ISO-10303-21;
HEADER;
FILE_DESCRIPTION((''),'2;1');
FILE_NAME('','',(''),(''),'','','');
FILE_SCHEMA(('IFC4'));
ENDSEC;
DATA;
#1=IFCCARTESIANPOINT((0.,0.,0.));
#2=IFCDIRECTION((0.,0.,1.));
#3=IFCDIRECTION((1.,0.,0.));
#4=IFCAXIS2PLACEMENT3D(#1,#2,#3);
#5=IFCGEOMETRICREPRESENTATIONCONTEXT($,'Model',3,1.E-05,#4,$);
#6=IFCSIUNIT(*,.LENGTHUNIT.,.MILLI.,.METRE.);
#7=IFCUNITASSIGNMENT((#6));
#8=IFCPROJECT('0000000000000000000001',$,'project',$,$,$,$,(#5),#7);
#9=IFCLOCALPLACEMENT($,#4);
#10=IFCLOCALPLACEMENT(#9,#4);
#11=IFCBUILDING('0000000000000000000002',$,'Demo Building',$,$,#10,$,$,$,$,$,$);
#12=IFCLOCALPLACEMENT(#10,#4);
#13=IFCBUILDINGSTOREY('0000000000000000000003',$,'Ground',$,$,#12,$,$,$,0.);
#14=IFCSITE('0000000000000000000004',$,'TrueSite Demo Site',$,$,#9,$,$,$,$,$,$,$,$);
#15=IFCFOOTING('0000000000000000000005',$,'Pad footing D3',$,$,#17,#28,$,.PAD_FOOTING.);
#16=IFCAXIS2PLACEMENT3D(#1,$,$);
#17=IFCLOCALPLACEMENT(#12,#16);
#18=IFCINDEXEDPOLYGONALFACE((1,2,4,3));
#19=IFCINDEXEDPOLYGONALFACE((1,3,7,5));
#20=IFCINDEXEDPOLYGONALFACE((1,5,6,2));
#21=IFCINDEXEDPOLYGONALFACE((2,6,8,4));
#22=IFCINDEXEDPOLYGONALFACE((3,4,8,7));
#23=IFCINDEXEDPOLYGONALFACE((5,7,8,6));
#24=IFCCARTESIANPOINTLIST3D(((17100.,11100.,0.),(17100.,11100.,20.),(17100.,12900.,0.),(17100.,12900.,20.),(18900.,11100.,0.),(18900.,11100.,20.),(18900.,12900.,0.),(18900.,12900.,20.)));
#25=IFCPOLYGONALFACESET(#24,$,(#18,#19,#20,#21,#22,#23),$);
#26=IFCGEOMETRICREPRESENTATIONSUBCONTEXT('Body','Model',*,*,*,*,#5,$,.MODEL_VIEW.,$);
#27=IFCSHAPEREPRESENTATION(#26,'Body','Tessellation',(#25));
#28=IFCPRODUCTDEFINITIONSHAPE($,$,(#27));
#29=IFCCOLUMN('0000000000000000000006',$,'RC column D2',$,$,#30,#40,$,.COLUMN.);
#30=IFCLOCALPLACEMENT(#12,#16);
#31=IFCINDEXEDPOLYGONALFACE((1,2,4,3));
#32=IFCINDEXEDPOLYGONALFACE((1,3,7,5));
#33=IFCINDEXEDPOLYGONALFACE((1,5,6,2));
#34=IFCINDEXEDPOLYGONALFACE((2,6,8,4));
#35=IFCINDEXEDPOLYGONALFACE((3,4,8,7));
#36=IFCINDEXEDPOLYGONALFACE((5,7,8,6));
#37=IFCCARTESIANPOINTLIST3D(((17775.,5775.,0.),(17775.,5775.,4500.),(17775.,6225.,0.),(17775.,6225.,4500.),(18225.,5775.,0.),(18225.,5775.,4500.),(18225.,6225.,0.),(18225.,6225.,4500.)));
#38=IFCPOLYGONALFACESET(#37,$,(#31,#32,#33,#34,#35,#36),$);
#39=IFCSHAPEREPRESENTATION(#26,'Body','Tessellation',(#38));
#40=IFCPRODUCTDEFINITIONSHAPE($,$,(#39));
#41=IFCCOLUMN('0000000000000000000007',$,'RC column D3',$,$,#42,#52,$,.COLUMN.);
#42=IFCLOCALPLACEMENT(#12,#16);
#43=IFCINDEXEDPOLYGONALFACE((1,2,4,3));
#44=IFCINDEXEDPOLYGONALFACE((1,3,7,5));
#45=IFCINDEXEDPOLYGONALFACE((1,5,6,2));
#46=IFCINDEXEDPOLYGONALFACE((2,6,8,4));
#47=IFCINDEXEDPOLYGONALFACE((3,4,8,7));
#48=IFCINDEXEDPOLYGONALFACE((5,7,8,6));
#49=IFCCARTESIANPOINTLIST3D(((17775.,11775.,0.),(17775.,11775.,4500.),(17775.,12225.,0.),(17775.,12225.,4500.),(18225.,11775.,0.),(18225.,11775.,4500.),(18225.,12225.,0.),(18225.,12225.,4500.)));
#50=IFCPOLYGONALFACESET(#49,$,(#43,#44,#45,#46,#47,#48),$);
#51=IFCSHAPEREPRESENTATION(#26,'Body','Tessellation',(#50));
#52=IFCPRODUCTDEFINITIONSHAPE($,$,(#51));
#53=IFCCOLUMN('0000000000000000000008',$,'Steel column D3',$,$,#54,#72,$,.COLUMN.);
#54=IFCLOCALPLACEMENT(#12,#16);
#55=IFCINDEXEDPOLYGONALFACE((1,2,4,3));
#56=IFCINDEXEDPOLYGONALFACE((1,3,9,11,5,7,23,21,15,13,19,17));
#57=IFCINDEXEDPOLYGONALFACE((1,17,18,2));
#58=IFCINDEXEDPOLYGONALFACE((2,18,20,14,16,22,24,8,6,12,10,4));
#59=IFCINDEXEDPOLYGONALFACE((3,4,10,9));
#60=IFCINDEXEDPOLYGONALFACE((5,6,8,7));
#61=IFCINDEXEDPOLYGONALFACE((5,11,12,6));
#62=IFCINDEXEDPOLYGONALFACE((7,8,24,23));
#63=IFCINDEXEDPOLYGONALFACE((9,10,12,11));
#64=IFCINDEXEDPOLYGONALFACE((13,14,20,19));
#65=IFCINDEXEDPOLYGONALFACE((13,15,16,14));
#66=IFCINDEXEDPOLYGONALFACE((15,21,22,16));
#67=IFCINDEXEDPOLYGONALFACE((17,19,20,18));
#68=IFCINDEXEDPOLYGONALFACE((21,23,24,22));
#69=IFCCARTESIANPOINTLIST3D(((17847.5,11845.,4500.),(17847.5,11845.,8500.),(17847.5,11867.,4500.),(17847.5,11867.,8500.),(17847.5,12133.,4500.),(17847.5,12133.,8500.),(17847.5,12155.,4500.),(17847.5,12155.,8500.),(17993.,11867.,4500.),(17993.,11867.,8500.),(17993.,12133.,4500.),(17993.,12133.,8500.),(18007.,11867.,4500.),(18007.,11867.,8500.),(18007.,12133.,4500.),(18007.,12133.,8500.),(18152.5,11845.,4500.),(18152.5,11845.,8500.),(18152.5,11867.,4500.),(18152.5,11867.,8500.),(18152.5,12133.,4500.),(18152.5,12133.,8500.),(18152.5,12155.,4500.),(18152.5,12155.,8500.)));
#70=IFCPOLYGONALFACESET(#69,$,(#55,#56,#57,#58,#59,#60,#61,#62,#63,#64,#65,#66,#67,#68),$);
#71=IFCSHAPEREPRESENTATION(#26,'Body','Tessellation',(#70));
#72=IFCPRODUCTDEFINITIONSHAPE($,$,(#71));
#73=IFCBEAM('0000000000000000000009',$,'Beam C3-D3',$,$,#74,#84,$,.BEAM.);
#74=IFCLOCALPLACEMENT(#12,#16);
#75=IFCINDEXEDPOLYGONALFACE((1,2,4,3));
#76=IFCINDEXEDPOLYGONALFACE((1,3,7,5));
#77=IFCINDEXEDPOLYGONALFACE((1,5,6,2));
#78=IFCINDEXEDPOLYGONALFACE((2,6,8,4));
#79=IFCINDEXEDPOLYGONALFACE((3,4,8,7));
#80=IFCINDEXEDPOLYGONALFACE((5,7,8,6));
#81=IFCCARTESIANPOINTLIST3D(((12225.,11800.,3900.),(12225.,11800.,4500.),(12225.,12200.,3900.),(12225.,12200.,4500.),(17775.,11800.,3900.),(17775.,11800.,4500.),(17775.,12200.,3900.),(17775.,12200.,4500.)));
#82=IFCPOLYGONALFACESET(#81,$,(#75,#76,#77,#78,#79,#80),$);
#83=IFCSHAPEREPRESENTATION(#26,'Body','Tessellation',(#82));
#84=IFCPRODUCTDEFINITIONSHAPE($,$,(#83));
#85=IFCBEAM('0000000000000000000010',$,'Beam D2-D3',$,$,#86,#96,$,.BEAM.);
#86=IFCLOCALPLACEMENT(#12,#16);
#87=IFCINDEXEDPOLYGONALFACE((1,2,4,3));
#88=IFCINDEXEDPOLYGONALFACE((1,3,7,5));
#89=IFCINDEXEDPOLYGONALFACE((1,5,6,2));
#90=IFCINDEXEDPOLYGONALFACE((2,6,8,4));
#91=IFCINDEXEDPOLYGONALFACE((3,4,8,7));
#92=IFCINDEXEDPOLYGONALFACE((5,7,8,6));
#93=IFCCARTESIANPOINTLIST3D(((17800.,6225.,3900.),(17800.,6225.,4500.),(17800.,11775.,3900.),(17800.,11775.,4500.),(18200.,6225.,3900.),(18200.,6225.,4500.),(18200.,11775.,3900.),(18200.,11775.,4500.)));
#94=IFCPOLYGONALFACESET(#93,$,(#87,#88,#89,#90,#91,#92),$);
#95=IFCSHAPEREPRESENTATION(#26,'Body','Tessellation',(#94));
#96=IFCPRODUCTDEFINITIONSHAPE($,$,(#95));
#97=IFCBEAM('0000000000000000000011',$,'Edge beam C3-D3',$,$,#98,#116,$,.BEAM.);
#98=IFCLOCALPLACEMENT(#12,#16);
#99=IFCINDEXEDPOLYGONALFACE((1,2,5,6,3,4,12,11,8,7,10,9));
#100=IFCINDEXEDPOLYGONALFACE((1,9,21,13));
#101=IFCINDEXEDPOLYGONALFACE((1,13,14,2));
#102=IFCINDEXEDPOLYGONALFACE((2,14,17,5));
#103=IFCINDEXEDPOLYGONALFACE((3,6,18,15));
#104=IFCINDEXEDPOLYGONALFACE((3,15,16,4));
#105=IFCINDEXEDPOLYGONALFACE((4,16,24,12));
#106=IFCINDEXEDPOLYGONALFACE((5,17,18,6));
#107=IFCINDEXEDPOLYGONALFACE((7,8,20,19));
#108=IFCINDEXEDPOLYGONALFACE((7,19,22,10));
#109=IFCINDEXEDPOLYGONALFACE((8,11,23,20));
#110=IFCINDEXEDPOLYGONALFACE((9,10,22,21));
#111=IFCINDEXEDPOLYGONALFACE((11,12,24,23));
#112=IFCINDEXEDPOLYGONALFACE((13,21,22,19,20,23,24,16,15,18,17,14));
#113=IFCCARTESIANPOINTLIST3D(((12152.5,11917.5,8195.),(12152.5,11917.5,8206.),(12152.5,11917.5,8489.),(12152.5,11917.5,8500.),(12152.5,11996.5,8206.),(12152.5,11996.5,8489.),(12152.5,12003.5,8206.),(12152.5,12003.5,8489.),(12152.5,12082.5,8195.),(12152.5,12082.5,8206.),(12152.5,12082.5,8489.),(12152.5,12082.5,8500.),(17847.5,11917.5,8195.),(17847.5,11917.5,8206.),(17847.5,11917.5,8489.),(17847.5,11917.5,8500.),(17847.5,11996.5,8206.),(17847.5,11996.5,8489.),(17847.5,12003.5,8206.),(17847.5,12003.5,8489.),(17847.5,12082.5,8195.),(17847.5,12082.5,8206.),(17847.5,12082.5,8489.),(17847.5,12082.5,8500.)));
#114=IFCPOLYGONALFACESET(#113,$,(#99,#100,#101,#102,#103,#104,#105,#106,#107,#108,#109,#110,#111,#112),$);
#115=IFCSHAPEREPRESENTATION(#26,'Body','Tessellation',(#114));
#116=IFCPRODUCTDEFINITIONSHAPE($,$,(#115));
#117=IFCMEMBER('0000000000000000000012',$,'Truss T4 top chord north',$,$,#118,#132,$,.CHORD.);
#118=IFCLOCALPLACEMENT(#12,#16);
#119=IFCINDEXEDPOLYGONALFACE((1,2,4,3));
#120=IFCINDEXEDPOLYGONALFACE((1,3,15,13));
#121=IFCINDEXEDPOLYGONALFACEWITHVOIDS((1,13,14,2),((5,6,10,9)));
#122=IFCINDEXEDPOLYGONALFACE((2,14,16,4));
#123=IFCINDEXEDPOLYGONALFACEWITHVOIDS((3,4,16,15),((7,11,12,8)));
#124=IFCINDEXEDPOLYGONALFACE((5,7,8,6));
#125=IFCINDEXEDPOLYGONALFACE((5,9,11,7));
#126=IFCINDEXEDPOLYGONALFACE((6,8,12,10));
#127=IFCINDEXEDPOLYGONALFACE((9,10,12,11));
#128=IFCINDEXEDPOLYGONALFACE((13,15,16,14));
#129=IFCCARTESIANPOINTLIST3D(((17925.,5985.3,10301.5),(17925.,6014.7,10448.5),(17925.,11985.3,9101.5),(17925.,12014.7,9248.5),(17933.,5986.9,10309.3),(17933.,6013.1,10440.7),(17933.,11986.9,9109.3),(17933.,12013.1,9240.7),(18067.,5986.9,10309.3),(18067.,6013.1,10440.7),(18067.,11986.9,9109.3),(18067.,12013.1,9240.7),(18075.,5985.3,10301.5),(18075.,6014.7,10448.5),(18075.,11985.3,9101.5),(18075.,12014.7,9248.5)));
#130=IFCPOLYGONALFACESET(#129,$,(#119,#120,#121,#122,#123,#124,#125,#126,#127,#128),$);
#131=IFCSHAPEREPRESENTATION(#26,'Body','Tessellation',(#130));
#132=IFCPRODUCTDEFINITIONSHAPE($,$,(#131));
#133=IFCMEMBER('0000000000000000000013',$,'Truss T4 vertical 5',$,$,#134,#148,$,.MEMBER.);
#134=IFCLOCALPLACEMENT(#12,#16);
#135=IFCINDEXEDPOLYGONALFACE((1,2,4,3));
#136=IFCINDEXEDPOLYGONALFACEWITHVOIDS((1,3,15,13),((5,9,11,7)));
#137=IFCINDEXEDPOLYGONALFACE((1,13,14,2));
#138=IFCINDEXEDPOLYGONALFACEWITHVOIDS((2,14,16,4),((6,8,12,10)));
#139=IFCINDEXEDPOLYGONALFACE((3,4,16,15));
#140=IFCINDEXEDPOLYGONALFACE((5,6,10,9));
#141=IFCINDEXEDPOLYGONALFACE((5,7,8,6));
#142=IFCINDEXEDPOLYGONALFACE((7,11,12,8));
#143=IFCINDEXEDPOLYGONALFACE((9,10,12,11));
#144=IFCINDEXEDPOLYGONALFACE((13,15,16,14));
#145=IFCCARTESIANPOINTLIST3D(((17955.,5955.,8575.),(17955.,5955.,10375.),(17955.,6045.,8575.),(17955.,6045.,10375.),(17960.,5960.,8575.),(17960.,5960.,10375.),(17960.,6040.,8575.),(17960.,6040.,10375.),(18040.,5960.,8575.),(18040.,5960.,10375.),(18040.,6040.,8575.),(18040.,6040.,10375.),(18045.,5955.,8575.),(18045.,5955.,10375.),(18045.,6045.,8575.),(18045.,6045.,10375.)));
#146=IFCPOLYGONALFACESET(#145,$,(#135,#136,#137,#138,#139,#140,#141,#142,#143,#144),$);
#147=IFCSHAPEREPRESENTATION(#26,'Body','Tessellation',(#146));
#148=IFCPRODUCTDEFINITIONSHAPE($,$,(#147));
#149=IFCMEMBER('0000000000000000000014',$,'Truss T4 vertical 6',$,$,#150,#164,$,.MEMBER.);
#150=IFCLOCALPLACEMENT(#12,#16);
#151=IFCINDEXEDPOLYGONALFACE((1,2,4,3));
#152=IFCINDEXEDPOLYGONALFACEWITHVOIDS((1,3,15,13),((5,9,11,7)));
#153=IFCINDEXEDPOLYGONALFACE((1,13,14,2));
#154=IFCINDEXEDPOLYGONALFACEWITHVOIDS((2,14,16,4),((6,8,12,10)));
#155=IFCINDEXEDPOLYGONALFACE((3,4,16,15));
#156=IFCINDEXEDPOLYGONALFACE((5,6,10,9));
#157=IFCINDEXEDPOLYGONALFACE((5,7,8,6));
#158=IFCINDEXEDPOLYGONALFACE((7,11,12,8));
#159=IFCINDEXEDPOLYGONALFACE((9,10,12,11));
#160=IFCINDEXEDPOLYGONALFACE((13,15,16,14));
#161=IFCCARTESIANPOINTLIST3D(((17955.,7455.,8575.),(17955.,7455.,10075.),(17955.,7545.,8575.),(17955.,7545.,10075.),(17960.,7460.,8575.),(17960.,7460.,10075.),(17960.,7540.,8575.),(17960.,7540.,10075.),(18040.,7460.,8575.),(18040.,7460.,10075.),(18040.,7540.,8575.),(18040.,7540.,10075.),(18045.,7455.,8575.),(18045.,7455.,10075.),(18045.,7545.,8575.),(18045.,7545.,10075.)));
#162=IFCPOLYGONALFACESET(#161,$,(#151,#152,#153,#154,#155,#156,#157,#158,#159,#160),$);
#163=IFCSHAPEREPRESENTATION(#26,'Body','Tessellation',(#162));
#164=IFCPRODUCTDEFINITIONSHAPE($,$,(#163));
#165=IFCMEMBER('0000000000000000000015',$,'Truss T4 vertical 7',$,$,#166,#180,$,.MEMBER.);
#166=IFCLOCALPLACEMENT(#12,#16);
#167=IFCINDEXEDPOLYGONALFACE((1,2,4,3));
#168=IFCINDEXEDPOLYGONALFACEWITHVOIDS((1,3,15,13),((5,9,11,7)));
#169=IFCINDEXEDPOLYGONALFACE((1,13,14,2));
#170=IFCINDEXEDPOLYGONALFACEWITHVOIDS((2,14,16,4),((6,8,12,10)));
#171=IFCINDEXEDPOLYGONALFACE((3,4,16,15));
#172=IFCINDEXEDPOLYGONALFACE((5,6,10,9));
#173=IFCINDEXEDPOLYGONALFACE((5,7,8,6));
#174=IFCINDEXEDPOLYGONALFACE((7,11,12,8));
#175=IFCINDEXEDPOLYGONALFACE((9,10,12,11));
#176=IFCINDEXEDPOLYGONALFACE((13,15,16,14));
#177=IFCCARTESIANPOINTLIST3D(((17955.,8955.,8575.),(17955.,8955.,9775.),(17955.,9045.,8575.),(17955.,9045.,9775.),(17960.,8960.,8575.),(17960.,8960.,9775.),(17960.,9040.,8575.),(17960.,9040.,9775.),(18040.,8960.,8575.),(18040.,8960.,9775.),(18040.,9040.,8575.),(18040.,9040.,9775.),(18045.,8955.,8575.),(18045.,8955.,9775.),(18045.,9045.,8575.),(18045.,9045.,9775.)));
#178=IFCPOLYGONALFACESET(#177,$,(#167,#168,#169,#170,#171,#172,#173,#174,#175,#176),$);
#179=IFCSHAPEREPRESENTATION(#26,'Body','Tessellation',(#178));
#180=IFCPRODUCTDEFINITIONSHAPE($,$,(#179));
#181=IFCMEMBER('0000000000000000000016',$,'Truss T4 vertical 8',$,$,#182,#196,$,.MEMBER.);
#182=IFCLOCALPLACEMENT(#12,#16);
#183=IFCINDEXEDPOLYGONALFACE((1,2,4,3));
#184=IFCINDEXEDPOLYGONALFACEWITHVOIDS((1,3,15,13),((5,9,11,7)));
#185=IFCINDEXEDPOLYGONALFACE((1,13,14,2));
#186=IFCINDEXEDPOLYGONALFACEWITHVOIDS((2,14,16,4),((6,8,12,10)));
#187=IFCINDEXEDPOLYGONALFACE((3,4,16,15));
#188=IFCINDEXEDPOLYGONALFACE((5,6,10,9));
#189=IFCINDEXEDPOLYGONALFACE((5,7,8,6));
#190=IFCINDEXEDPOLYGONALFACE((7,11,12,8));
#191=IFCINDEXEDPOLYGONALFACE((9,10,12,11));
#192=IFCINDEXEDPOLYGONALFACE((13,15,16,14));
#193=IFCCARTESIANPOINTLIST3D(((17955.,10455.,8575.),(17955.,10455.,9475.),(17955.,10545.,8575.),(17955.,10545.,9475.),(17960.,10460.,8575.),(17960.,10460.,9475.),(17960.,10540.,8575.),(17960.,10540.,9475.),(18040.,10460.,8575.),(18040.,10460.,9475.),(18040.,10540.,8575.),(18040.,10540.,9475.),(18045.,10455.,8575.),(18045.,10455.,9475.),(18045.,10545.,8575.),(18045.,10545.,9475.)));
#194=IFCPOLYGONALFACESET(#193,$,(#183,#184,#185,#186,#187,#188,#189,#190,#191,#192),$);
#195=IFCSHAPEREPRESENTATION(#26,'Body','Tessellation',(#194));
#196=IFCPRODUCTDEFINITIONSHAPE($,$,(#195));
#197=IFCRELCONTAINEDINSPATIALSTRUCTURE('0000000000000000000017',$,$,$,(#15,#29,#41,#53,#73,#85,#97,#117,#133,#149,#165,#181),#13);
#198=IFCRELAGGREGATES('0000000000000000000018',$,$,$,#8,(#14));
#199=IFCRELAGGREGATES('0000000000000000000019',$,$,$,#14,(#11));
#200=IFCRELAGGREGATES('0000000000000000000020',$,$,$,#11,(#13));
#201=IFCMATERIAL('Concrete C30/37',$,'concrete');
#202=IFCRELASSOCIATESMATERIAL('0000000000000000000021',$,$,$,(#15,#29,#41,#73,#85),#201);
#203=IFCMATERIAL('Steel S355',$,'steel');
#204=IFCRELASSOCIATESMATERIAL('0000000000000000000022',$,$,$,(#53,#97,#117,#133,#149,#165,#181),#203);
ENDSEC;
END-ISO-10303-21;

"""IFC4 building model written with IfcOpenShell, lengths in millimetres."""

from ifc_helpers import new_model, si_unit, frame, origin_with_axes, place, context, subcontext, project, spatial, rectangle, hollow_rectangle, i_section, extrude, material, element, save


model = new_model("IFC4")

# Units and contexts
model_context = context("Model", 3, precision=1e-05, world=origin_with_axes())
body_context = subcontext(model_context, "Body", "Model", "MODEL_VIEW")
ifc_project = project(units=[si_unit("LENGTHUNIT", "METRE", prefix="MILLI")], contexts=[model_context])

# Site, building, storey
site_placement = place(None, origin_with_axes())
site = spatial("IfcSite", under=ifc_project, at=site_placement, Name="TrueSite Demo Site")
building_placement = place(site_placement, origin_with_axes())
building = spatial("IfcBuilding", under=site, at=building_placement, Name="Demo Building")
storey_placement = place(building_placement, origin_with_axes())
storey = spatial("IfcBuildingStorey", under=building, at=storey_placement, Name="Ground", Elevation=0.0)

# Footing
ifc_material_1 = material(Name="Concrete C30/37", Category="concrete")
footing_placement = place(storey_placement, frame((18000.0, 12000.0, 0.0), z_axis=(0.0, 0.0, 1.0), x_axis=(1.0, 0.0, 0.0)))
element("IfcFooting", 1, at=footing_placement, inside=storey, material=ifc_material_1, Name="Pad footing D3", PredefinedType="PAD_FOOTING", context=body_context, shape_type="SweptSolid", body=[
    extrude(rectangle(XDim=1800.0, YDim=1800.0), origin_with_axes(), (0.0, 0.0, 1.0), 20.0),
])

# Columns
for number, where, z_axis, x_axis, name in (
    (2, (18000.0, 6000.0, 0.0), (0.0, 0.0, 1.0), (1.0, 0.0, 0.0), "RC column D2"),
    (3, (18000.0, 12000.0, 0.0), (0.0, 0.0, 1.0), (1.0, 0.0, 0.0), "RC column D3"),
):
    element("IfcColumn", number, at=place(storey_placement, frame(where, z_axis=z_axis, x_axis=x_axis)), inside=storey, material=ifc_material_1, Name=name, PredefinedType="COLUMN", context=body_context, shape_type="SweptSolid", body=[
        extrude(rectangle(XDim=450.0, YDim=450.0), origin_with_axes(), (0.0, 0.0, 1.0), 4500.0),
    ])
ifc_material_2 = material(Name="Steel S355", Category="steel")
column_placement = place(storey_placement, frame((18000.0, 12000.0, 4500.0), z_axis=(0.0, 0.0, 1.0), x_axis=(1.0, 0.0, 0.0)))
element("IfcColumn", 4, at=column_placement, inside=storey, material=ifc_material_2, Name="Steel column D3", PredefinedType="COLUMN", context=body_context, shape_type="SweptSolid", body=[
    extrude(i_section(OverallWidth=305.0, OverallDepth=310.0, WebThickness=14.0, FlangeThickness=22.0), origin_with_axes(), (0.0, 0.0, 1.0), 4000.0),
])

# Beams
beam_1_placement = place(storey_placement, frame((12225.0, 12000.0, 4200.0), z_axis=(1.0, 0.0, 0.0), x_axis=(0.0, 1.0, 0.0)))
element("IfcBeam", 5, at=beam_1_placement, inside=storey, material=ifc_material_1, Name="Beam C3-D3", PredefinedType="BEAM", context=body_context, shape_type="SweptSolid", body=[
    extrude(rectangle(XDim=400.0, YDim=600.0), origin_with_axes(), (0.0, 0.0, 1.0), 5550.0),
])
beam_2_placement = place(storey_placement, frame((18000.0, 6225.0, 4200.0), z_axis=(0.0, 1.0, 0.0), x_axis=(-1.0, 0.0, 0.0)))
element("IfcBeam", 6, at=beam_2_placement, inside=storey, material=ifc_material_1, Name="Beam D2-D3", PredefinedType="BEAM", context=body_context, shape_type="SweptSolid", body=[
    extrude(rectangle(XDim=400.0, YDim=600.0), origin_with_axes(), (0.0, 0.0, 1.0), 5550.0),
])
beam_3_placement = place(storey_placement, frame((12152.5, 12000.0, 8347.5), z_axis=(1.0, 0.0, 0.0), x_axis=(0.0, 1.0, 0.0)))
element("IfcBeam", 7, at=beam_3_placement, inside=storey, material=ifc_material_2, Name="Edge beam C3-D3", PredefinedType="BEAM", context=body_context, shape_type="SweptSolid", body=[
    extrude(i_section(OverallWidth=165.0, OverallDepth=305.0, WebThickness=7.0, FlangeThickness=11.0), origin_with_axes(), (0.0, 0.0, 1.0), 5695.0),
])

# Members
member_1_placement = place(storey_placement, frame((18000.0, 6000.0, 10375.0), z_axis=(0.0, 0.980581, -0.196116), x_axis=(-1.0, 0.0, 0.0)))
element("IfcMember", 8, at=member_1_placement, inside=storey, material=ifc_material_2, Name="Truss T4 top chord north", PredefinedType="CHORD", context=body_context, shape_type="SweptSolid", body=[
    extrude(hollow_rectangle(XDim=150.0, YDim=150.0, WallThickness=8.0), origin_with_axes(), (0.0, 0.0, 1.0), 6118.8),
])
member_2_placement = place(storey_placement, frame((18000.0, 6000.0, 8575.0), z_axis=(0.0, 0.0, 1.0), x_axis=(1.0, 0.0, 0.0)))
element("IfcMember", 9, at=member_2_placement, inside=storey, material=ifc_material_2, Name="Truss T4 vertical 5", PredefinedType="MEMBER", context=body_context, shape_type="SweptSolid", body=[
    extrude(hollow_rectangle(XDim=90.0, YDim=90.0, WallThickness=5.0), origin_with_axes(), (0.0, 0.0, 1.0), 1800.0),
])
member_3_placement = place(storey_placement, frame((18000.0, 7500.0, 8575.0), z_axis=(0.0, 0.0, 1.0), x_axis=(1.0, 0.0, 0.0)))
element("IfcMember", 10, at=member_3_placement, inside=storey, material=ifc_material_2, Name="Truss T4 vertical 6", PredefinedType="MEMBER", context=body_context, shape_type="SweptSolid", body=[
    extrude(hollow_rectangle(XDim=90.0, YDim=90.0, WallThickness=5.0), origin_with_axes(), (0.0, 0.0, 1.0), 1500.0),
])
member_4_placement = place(storey_placement, frame((18000.0, 9000.0, 8575.0), z_axis=(0.0, 0.0, 1.0), x_axis=(1.0, 0.0, 0.0)))
element("IfcMember", 11, at=member_4_placement, inside=storey, material=ifc_material_2, Name="Truss T4 vertical 7", PredefinedType="MEMBER", context=body_context, shape_type="SweptSolid", body=[
    extrude(hollow_rectangle(XDim=90.0, YDim=90.0, WallThickness=5.0), origin_with_axes(), (0.0, 0.0, 1.0), 1200.0),
])
member_5_placement = place(storey_placement, frame((18000.0, 10500.0, 8575.0), z_axis=(0.0, 0.0, 1.0), x_axis=(1.0, 0.0, 0.0)))
element("IfcMember", 12, at=member_5_placement, inside=storey, material=ifc_material_2, Name="Truss T4 vertical 8", PredefinedType="MEMBER", context=body_context, shape_type="SweptSolid", body=[
    extrude(hollow_rectangle(XDim=90.0, YDim=90.0, WallThickness=5.0), origin_with_axes(), (0.0, 0.0, 1.0), 900.0),
])

save(model, "model.ifc")
